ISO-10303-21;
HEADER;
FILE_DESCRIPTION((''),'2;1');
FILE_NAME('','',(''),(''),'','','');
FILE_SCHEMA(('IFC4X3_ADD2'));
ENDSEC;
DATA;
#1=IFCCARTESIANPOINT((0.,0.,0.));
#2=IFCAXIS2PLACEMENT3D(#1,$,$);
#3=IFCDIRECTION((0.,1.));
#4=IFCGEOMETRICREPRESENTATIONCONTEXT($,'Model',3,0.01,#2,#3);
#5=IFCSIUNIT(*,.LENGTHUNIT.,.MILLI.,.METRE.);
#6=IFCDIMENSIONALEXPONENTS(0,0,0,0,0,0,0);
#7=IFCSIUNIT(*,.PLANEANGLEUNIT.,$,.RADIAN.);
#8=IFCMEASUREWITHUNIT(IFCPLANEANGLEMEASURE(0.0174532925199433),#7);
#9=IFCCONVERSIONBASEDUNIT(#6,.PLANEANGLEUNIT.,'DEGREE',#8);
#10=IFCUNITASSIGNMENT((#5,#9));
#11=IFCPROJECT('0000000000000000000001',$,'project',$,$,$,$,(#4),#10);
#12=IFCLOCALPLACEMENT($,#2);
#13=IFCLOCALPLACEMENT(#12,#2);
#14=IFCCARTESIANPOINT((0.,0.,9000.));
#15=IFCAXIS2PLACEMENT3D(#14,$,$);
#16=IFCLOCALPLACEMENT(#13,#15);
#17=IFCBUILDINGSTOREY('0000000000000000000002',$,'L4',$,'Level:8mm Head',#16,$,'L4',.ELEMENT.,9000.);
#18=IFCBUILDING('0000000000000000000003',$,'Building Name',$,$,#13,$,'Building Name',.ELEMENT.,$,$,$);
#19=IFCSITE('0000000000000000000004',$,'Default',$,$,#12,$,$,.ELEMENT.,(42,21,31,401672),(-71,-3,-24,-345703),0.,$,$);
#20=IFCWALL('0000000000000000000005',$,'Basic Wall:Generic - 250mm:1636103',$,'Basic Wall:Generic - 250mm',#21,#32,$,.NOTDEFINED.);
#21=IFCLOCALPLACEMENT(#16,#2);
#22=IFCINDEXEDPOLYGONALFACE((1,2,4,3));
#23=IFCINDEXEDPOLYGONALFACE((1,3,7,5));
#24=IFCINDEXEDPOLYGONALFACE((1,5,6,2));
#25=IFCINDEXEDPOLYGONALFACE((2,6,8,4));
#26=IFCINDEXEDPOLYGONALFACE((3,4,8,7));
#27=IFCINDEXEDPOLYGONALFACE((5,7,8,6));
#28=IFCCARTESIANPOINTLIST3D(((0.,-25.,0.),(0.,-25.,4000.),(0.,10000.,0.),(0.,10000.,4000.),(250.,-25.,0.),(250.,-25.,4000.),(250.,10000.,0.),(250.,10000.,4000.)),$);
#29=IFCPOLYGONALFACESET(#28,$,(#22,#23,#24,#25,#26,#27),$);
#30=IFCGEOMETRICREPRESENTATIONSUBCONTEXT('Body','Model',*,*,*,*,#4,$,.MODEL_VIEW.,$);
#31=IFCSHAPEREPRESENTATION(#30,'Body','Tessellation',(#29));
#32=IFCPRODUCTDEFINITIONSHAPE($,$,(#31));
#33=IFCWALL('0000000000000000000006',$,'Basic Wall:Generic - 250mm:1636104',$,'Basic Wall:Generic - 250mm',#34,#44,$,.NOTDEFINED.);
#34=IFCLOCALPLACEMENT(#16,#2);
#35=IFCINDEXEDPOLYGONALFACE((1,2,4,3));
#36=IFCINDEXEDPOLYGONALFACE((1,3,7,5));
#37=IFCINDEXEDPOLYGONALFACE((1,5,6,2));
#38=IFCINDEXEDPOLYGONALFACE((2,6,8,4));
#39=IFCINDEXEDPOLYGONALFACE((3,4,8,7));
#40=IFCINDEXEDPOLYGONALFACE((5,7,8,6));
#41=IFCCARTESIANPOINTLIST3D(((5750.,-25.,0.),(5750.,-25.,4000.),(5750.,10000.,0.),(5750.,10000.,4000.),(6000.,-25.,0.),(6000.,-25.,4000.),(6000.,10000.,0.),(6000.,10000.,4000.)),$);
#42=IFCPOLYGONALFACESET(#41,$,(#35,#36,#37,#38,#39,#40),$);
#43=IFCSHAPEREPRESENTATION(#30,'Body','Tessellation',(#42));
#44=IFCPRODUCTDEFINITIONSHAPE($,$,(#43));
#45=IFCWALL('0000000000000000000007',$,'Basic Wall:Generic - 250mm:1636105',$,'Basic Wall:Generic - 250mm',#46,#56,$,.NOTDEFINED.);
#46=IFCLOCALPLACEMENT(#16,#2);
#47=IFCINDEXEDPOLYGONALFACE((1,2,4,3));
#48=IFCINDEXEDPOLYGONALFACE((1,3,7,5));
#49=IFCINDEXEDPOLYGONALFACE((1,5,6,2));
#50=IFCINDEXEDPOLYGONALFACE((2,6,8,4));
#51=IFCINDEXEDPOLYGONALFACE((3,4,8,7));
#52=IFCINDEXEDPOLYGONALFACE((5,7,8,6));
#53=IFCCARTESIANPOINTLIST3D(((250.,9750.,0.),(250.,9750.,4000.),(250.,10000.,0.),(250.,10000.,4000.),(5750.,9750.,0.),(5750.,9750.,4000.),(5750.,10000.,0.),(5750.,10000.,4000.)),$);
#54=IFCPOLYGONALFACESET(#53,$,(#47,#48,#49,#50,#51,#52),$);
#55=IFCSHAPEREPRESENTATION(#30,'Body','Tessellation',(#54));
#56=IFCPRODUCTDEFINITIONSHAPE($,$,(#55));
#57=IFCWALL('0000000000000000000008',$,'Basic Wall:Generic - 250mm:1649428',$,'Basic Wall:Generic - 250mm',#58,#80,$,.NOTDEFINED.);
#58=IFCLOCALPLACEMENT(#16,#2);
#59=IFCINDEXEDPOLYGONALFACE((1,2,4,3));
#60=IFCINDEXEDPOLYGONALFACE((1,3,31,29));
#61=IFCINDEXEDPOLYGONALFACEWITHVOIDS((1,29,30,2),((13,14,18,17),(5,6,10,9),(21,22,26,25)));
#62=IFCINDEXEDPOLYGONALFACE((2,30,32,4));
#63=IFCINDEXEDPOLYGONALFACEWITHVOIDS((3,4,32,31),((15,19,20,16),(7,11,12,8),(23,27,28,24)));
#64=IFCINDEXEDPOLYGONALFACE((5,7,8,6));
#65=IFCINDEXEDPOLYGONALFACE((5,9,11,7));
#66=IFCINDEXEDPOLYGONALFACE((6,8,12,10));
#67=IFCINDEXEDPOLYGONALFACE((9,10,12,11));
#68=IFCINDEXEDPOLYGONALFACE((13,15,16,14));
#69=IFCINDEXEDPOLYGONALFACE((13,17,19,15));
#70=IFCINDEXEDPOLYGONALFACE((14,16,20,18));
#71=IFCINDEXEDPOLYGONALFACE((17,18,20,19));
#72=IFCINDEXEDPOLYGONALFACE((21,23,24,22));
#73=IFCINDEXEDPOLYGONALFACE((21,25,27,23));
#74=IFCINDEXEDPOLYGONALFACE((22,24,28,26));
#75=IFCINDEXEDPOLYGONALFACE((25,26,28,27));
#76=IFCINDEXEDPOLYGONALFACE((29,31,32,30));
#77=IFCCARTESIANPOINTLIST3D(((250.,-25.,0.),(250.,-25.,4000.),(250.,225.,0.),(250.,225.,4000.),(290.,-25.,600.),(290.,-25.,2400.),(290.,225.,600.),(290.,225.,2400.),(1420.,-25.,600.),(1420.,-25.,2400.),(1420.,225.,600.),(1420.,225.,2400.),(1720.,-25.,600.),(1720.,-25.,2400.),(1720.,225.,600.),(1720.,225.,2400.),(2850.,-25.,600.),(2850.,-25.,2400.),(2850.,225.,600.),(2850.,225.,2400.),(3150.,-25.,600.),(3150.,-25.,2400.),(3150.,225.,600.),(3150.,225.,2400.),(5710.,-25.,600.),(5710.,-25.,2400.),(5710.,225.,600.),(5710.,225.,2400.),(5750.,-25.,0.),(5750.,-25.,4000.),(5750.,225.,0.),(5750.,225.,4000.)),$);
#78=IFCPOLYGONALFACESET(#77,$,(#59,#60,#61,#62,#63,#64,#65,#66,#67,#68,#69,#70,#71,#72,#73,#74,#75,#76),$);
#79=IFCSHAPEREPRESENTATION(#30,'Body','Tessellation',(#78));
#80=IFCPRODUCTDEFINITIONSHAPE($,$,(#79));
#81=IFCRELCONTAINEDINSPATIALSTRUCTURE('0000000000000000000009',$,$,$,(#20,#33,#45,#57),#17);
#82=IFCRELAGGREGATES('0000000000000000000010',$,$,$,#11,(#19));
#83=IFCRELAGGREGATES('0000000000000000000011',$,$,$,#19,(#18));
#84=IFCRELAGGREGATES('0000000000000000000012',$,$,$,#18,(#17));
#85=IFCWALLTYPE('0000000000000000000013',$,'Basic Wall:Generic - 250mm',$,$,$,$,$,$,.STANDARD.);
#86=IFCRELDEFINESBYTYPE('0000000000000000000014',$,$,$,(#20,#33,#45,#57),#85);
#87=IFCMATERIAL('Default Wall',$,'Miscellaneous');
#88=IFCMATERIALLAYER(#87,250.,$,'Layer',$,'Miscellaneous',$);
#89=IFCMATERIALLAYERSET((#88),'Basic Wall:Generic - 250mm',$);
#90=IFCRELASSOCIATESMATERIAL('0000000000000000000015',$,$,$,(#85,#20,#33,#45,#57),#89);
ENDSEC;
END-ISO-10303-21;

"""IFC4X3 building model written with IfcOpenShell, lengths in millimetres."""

from ifc_helpers import new_model, entity, si_unit, converted_unit, direction, frame, frame_2d, origin, place, context, subcontext, project, spatial, rectangle, extrude, material, layer, layer_set, type_object, element, save


model = new_model("IFC4X3")

# Units and contexts
model_context = context("Model", 3, precision=0.01, world=origin(), true_north=direction((0.0, 1.0)))
body_context = subcontext(model_context, "Body", "Model", "MODEL_VIEW")
ifc_project = project(units=[si_unit("LENGTHUNIT", "METRE", prefix="MILLI"), converted_unit("PLANEANGLEUNIT", "DEGREE", entity("IfcPlaneAngleMeasure", 0.0174532925199433), si_unit("PLANEANGLEUNIT", "RADIAN"), dimensions=[0, 0, 0, 0, 0, 0, 0])], contexts=[model_context])

# Site, building, storey
site_placement = place(None, origin())
site = spatial("IfcSite", under=ifc_project, at=site_placement, Name="Default", CompositionType="ELEMENT", RefLatitude=(42, 21, 31, 401672), RefLongitude=(-71, -3, -24, -345703), RefElevation=0.0)
building_placement = place(site_placement, origin())
building = spatial("IfcBuilding", under=site, at=building_placement, Name="Building Name", LongName="Building Name", CompositionType="ELEMENT")
storey_placement = place(building_placement, frame((0.0, 0.0, 9000.0)))
storey = spatial("IfcBuildingStorey", under=building, at=storey_placement, Name="L4", ObjectType="Level:8mm Head", LongName="L4", CompositionType="ELEMENT", Elevation=9000.0)

# Walls
ifc_material = material(Name="Default Wall", Category="Miscellaneous")
ifc_layer = layer(ifc_material, 250.0, Name="Layer", Category="Miscellaneous")
ifc_layer_set = layer_set([ifc_layer], Name="Basic Wall:Generic - 250mm")
wall_type = type_object("IfcWallType", Name="Basic Wall:Generic - 250mm", PredefinedType="STANDARD", material=ifc_layer_set)
wall_1_placement = place(storey_placement, frame((125.0, 10000.0, 0.0), z_axis=(0.0, 0.0, 1.0), x_axis=(0.0, -1.0, 0.0)))
element("IfcWall", 1, at=wall_1_placement, inside=storey, type_object=wall_type, material=ifc_layer_set, Name="Basic Wall:Generic - 250mm:1636103", ObjectType="Basic Wall:Generic - 250mm", PredefinedType="NOTDEFINED", context=body_context, shape_type="SweptSolid", body=[
    extrude(rectangle(XDim=10025.0, YDim=250.0, at=frame_2d((5012.5, 0.0), x_axis=(-1.0, 0.0))), origin(), (0.0, 0.0, 1.0), 4000.0),
])
wall_2_placement = place(storey_placement, frame((5875.0, -25.0, 0.0), z_axis=(0.0, 0.0, 1.0), x_axis=(0.0, 1.0, 0.0)))
element("IfcWall", 2, at=wall_2_placement, inside=storey, type_object=wall_type, material=ifc_layer_set, Name="Basic Wall:Generic - 250mm:1636104", ObjectType="Basic Wall:Generic - 250mm", PredefinedType="NOTDEFINED", context=body_context, shape_type="SweptSolid", body=[
    extrude(rectangle(XDim=10025.0, YDim=250.0, at=frame_2d((5012.5, 0.0), x_axis=(-1.0, 0.0))), origin(), (0.0, 0.0, 1.0), 4000.0),
])
wall_3_placement = place(storey_placement, frame((5750.0, 9875.0, 0.0), z_axis=(0.0, 0.0, 1.0), x_axis=(-1.0, 0.0, 0.0)))
element("IfcWall", 3, at=wall_3_placement, inside=storey, type_object=wall_type, material=ifc_layer_set, Name="Basic Wall:Generic - 250mm:1636105", ObjectType="Basic Wall:Generic - 250mm", PredefinedType="NOTDEFINED", context=body_context, shape_type="SweptSolid", body=[
    extrude(rectangle(XDim=5500.0, YDim=250.0, at=frame_2d((2750.0, 0.0), x_axis=(-1.0, 0.0))), origin(), (0.0, 0.0, 1.0), 4000.0),
])

# Wall, openings
wall_4_placement = place(storey_placement, frame((250.0, 100.0, 0.0)))
wall_4 = element("IfcWall", 4, at=wall_4_placement, inside=storey, type_object=wall_type, material=ifc_layer_set, Name="Basic Wall:Generic - 250mm:1649428", ObjectType="Basic Wall:Generic - 250mm", PredefinedType="NOTDEFINED", context=body_context, shape_type="SweptSolid", body=[
    extrude(rectangle(XDim=5500.0, YDim=250.0, at=frame_2d((2750.0, 0.0), x_axis=(-1.0, 0.0))), origin(), (0.0, 0.0, 1.0), 4000.0),
])
opening_1_placement = place(wall_4_placement, frame((1470.0, -125.0, 600.0)))
element("IfcOpeningElement", 5, at=opening_1_placement, cuts=wall_4, PredefinedType="OPENING", context=body_context, shape_type="SweptSolid", body=[
    extrude(rectangle(XDim=1800.0, YDim=1130.0, at=frame_2d((900.0, 565.0), x_axis=(-1.0, 0.0))), frame((0.0, 0.0, 0.0), z_axis=(0.0, 1.0, 0.0), x_axis=(0.0, 0.0, 1.0)), (0.0, 0.0, 1.0), 250.0),
])
opening_2_placement = place(wall_4_placement, frame((2900.0, -125.0, 600.0)))
element("IfcOpeningElement", 6, at=opening_2_placement, cuts=wall_4, PredefinedType="OPENING", context=body_context, shape_type="SweptSolid", body=[
    extrude(rectangle(XDim=1800.0, YDim=2560.0, at=frame_2d((900.0, 1280.0), x_axis=(-1.0, 0.0))), frame((0.0, 0.0, 0.0), z_axis=(0.0, 1.0, 0.0), x_axis=(0.0, 0.0, 1.0)), (0.0, 0.0, 1.0), 250.0),
])
opening_3_placement = place(wall_4_placement, frame((40.0, -125.0, 600.0)))
element("IfcOpeningElement", 7, at=opening_3_placement, cuts=wall_4, PredefinedType="OPENING", context=body_context, shape_type="SweptSolid", body=[
    extrude(rectangle(XDim=1800.0, YDim=1130.0, at=frame_2d((900.0, 565.0), x_axis=(-1.0, 0.0))), frame((0.0, 0.0, 0.0), z_axis=(0.0, 1.0, 0.0), x_axis=(0.0, 0.0, 1.0)), (0.0, 0.0, 1.0), 250.0),
])

save(model, "model.ifc")
